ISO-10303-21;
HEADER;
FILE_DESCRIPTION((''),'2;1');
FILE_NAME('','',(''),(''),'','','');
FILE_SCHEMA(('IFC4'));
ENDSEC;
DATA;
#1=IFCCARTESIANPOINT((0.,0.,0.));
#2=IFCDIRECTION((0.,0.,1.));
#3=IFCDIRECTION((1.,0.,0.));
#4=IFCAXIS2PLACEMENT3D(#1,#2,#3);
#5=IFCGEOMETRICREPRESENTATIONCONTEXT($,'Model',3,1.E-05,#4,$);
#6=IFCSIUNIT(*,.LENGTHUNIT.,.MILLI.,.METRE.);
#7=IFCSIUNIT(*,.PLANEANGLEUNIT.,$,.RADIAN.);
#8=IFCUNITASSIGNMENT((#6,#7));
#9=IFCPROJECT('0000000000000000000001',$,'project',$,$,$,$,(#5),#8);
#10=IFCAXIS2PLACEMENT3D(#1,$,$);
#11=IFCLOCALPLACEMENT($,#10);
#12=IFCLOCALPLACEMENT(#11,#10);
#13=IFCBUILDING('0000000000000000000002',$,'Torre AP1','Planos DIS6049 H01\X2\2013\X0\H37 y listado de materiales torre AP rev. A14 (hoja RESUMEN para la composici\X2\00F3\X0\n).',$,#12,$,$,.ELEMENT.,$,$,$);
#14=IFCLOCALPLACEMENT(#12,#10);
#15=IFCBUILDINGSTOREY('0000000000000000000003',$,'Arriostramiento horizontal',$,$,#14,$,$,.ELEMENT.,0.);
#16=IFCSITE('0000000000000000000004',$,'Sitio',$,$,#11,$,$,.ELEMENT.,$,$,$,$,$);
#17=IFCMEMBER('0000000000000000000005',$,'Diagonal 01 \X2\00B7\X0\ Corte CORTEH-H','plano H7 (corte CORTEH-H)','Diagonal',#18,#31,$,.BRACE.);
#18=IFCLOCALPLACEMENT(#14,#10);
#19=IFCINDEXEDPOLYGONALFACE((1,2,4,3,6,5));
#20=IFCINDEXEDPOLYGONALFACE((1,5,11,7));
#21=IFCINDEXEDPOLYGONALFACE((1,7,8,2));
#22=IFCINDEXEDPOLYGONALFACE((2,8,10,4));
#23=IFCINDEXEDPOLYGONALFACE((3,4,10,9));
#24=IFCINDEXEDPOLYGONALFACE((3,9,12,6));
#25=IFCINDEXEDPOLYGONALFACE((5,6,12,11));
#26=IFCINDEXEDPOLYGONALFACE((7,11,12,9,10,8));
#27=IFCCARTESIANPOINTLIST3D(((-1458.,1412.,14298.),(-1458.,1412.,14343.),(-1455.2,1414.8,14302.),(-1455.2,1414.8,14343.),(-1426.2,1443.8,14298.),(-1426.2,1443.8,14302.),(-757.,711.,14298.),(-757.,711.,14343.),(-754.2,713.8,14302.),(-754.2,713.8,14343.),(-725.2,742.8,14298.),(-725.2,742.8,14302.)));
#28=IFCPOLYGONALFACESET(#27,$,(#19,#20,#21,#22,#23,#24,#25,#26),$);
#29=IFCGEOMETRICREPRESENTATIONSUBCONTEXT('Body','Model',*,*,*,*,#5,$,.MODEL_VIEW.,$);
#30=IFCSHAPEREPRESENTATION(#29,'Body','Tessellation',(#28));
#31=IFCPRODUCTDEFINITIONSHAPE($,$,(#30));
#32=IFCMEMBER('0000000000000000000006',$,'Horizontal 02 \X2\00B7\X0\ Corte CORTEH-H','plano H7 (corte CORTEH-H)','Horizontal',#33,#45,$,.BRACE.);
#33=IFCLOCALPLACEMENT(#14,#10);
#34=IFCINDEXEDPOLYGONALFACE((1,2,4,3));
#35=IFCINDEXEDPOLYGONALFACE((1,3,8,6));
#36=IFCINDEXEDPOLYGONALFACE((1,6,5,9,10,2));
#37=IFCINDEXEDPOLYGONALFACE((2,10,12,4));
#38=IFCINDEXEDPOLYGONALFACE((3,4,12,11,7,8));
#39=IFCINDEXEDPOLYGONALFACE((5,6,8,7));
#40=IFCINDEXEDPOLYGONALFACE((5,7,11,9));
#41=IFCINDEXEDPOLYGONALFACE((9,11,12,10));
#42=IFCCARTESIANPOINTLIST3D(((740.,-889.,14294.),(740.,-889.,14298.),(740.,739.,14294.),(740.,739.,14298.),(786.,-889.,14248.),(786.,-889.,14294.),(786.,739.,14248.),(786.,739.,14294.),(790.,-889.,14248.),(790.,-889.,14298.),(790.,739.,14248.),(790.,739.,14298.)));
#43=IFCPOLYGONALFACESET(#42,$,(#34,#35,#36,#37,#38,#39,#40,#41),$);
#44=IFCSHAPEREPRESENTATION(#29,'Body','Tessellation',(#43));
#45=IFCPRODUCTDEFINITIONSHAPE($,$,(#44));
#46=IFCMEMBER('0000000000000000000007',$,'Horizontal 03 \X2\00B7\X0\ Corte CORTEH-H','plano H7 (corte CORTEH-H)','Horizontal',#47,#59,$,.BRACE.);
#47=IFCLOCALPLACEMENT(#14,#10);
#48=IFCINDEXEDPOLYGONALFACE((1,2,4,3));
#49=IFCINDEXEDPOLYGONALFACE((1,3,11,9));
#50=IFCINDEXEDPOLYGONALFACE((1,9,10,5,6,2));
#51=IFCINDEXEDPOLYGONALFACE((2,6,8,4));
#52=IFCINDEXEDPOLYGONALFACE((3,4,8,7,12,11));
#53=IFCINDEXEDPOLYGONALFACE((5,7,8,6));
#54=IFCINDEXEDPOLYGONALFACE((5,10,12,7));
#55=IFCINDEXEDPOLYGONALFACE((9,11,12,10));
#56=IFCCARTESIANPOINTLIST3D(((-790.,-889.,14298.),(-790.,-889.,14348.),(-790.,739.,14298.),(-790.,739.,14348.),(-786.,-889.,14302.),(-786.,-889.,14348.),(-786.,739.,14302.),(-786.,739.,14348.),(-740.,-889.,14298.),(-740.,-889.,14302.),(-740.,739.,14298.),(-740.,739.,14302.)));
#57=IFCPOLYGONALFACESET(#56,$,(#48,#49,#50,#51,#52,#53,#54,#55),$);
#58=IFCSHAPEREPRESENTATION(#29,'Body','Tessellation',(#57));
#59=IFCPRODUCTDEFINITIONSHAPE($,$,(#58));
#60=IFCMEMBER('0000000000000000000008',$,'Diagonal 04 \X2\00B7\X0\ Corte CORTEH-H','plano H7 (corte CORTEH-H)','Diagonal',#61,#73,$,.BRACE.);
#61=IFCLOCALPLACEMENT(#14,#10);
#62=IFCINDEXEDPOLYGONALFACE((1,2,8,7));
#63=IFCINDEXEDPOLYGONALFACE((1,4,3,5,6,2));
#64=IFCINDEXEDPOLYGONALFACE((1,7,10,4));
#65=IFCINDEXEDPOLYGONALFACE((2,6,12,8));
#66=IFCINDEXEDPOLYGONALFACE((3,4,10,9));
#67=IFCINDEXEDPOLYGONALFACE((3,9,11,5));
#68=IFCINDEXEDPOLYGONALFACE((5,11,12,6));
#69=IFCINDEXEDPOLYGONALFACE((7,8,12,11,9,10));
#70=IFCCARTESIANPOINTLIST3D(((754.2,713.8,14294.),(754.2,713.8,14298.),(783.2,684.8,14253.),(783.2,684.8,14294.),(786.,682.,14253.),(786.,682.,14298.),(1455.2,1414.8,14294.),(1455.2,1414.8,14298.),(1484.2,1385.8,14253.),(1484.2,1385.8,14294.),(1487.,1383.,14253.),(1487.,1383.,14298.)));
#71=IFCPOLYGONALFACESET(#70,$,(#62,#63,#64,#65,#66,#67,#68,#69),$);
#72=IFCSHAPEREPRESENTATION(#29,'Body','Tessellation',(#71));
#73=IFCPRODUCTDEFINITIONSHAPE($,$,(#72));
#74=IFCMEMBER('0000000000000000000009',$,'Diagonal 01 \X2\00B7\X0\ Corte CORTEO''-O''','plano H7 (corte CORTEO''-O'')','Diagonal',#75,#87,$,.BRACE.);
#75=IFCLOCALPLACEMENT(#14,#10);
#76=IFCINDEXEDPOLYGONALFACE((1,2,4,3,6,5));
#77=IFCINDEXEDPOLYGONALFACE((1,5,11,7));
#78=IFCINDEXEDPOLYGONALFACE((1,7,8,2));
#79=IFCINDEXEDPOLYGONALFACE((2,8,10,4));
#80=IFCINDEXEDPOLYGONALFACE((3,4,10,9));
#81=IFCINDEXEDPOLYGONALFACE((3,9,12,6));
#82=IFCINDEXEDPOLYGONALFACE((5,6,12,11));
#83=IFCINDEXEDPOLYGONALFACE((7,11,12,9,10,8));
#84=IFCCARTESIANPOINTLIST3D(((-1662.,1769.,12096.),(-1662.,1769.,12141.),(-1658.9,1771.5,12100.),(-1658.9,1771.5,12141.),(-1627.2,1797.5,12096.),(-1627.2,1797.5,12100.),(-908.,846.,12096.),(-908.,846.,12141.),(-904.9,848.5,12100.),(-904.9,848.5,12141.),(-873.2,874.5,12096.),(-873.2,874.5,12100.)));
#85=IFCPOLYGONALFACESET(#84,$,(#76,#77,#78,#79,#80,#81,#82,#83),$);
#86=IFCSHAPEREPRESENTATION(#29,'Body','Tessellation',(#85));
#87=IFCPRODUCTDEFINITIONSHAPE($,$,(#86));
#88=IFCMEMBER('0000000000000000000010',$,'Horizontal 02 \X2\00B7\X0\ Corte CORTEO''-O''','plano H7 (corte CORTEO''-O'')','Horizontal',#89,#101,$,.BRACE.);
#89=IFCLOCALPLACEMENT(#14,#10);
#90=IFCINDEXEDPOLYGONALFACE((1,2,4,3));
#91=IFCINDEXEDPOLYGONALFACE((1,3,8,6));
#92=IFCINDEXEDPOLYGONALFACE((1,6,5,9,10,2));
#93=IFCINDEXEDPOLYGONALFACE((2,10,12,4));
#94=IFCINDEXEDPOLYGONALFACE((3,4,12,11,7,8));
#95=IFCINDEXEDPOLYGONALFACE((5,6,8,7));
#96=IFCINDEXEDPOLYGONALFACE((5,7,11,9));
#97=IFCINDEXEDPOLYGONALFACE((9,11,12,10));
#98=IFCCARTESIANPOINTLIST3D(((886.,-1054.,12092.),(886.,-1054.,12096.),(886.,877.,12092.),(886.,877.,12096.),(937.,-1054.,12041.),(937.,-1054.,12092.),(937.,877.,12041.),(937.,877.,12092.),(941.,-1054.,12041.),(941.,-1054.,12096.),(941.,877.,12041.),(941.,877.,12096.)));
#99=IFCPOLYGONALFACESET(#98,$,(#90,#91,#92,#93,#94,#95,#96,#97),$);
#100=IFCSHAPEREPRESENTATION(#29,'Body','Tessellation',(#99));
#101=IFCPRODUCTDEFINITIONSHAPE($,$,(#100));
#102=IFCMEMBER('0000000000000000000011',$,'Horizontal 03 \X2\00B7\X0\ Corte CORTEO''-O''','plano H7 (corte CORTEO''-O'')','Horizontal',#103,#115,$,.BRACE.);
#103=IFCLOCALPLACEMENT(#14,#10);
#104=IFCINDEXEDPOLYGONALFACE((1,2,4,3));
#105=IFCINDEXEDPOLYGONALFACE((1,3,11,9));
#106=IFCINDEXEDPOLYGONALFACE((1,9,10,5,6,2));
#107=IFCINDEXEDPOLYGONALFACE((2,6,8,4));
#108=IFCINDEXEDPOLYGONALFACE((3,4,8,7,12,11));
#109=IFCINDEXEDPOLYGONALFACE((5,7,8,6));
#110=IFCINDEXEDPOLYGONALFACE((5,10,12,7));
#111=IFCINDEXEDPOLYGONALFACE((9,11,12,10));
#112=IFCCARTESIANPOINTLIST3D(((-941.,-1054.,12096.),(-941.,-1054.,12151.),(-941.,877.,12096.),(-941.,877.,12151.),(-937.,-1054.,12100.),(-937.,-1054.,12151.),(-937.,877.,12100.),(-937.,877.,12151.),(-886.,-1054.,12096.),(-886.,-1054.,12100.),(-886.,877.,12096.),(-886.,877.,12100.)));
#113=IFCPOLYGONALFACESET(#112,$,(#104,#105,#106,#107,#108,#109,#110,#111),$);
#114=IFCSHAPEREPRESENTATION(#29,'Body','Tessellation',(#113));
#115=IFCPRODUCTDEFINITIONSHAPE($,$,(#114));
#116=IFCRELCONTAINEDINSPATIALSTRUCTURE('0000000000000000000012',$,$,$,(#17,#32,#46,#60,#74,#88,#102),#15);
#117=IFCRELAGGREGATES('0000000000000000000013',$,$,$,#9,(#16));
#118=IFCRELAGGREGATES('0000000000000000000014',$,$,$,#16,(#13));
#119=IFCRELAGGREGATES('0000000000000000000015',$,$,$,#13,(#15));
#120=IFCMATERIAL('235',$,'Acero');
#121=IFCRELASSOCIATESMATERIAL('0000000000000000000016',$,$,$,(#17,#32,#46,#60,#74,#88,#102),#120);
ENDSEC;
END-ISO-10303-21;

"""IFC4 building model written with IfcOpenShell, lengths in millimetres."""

from ifc_helpers import new_model, si_unit, frame, frame_2d, origin, origin_with_axes, place, context, subcontext, project, spatial, l_section, extrude, material, element, save


model = new_model("IFC4")

# Units and contexts
model_context = context("Model", 3, precision=1e-05, world=origin_with_axes())
body_context = subcontext(model_context, "Body", "Model", "MODEL_VIEW")
ifc_project = project(units=[si_unit("LENGTHUNIT", "METRE", prefix="MILLI"), si_unit("PLANEANGLEUNIT", "RADIAN")], contexts=[model_context])

# Site, building, storey
site_placement = place(None, origin())
site = spatial("IfcSite", under=ifc_project, at=site_placement, Name="Sitio", CompositionType="ELEMENT")
building_placement = place(site_placement, origin())
building = spatial("IfcBuilding", under=site, at=building_placement, Name="Torre AP1", Description="Planos DIS6049 H01–H37 y listado de materiales torre AP rev. A14 (hoja RESUMEN para la composición).", CompositionType="ELEMENT")
storey_placement = place(building_placement, origin())
storey = spatial("IfcBuildingStorey", under=building, at=storey_placement, Name="Arriostramiento horizontal", CompositionType="ELEMENT", Elevation=0.0)

# Members
ifc_material = material(Name="235", Category="Acero")
member_1_placement = place(storey_placement, frame((-1458.0, 1412.0, 14298.0), z_axis=(0.707107, -0.707107, 0.0), x_axis=(0.707107, 0.707107, 0.0)))
element("IfcMember", 1, at=member_1_placement, inside=storey, material=ifc_material, Name="Diagonal 01 · Corte CORTEH-H", Description="plano H7 (corte CORTEH-H)", ObjectType="Diagonal", PredefinedType="BRACE", context=body_context, shape_type="SweptSolid", body=[
    extrude(l_section(Depth=45.0, Width=45.0, Thickness=4.0, at=frame_2d((22.5, 22.5))), None, (0.0, 0.0, 1.0), 991.4),
])
for number, where, z_axis, x_axis, name in (
    (2, (790.0, 739.0, 14298.0), (0.0, -1.0, 0.0), (-1.0, 0.0, 0.0), "Horizontal 02 · Corte CORTEH-H"),
    (3, (-790.0, 739.0, 14298.0), (0.0, -1.0, 0.0), (1.0, 0.0, 0.0), "Horizontal 03 · Corte CORTEH-H"),
):
    element("IfcMember", number, at=place(storey_placement, frame(where, z_axis=z_axis, x_axis=x_axis)), inside=storey, material=ifc_material, Name=name, Description="plano H7 (corte CORTEH-H)", ObjectType="Horizontal", PredefinedType="BRACE", context=body_context, shape_type="SweptSolid", body=[
        extrude(l_section(Depth=50.0, Width=50.0, Thickness=4.0, at=frame_2d((25.0, 25.0))), None, (0.0, 0.0, 1.0), 1628.0),
    ])
member_2_placement = place(storey_placement, frame((1487.0, 1383.0, 14298.0), z_axis=(-0.707107, -0.707107, 0.0), x_axis=(-0.707107, 0.707107, 0.0)))
element("IfcMember", 4, at=member_2_placement, inside=storey, material=ifc_material, Name="Diagonal 04 · Corte CORTEH-H", Description="plano H7 (corte CORTEH-H)", ObjectType="Diagonal", PredefinedType="BRACE", context=body_context, shape_type="SweptSolid", body=[
    extrude(l_section(Depth=45.0, Width=45.0, Thickness=4.0, at=frame_2d((22.5, 22.5))), None, (0.0, 0.0, 1.0), 991.4),
])
member_3_placement = place(storey_placement, frame((-1662.0, 1769.0, 12096.0), z_axis=(0.632644, -0.774443, 0.0), x_axis=(0.774443, 0.632644, 0.0)))
element("IfcMember", 5, at=member_3_placement, inside=storey, material=ifc_material, Name="Diagonal 01 · Corte CORTEO'-O'", Description="plano H7 (corte CORTEO'-O')", ObjectType="Diagonal", PredefinedType="BRACE", context=body_context, shape_type="SweptSolid", body=[
    extrude(l_section(Depth=45.0, Width=45.0, Thickness=4.0, at=frame_2d((22.5, 22.5))), None, (0.0, 0.0, 1.0), 1191.8),
])
for number, where, z_axis, x_axis, name in (
    (6, (941.0, 877.0, 12096.0), (0.0, -1.0, 0.0), (-1.0, 0.0, 0.0), "Horizontal 02 · Corte CORTEO'-O'"),
    (7, (-941.0, 877.0, 12096.0), (0.0, -1.0, 0.0), (1.0, 0.0, 0.0), "Horizontal 03 · Corte CORTEO'-O'"),
):
    element("IfcMember", number, at=place(storey_placement, frame(where, z_axis=z_axis, x_axis=x_axis)), inside=storey, material=ifc_material, Name=name, Description="plano H7 (corte CORTEO'-O')", ObjectType="Horizontal", PredefinedType="BRACE", context=body_context, shape_type="SweptSolid", body=[
        extrude(l_section(Depth=55.0, Width=55.0, Thickness=4.0, at=frame_2d((27.5, 27.5))), None, (0.0, 0.0, 1.0), 1931.0),
    ])

save(model, "model.ifc")
